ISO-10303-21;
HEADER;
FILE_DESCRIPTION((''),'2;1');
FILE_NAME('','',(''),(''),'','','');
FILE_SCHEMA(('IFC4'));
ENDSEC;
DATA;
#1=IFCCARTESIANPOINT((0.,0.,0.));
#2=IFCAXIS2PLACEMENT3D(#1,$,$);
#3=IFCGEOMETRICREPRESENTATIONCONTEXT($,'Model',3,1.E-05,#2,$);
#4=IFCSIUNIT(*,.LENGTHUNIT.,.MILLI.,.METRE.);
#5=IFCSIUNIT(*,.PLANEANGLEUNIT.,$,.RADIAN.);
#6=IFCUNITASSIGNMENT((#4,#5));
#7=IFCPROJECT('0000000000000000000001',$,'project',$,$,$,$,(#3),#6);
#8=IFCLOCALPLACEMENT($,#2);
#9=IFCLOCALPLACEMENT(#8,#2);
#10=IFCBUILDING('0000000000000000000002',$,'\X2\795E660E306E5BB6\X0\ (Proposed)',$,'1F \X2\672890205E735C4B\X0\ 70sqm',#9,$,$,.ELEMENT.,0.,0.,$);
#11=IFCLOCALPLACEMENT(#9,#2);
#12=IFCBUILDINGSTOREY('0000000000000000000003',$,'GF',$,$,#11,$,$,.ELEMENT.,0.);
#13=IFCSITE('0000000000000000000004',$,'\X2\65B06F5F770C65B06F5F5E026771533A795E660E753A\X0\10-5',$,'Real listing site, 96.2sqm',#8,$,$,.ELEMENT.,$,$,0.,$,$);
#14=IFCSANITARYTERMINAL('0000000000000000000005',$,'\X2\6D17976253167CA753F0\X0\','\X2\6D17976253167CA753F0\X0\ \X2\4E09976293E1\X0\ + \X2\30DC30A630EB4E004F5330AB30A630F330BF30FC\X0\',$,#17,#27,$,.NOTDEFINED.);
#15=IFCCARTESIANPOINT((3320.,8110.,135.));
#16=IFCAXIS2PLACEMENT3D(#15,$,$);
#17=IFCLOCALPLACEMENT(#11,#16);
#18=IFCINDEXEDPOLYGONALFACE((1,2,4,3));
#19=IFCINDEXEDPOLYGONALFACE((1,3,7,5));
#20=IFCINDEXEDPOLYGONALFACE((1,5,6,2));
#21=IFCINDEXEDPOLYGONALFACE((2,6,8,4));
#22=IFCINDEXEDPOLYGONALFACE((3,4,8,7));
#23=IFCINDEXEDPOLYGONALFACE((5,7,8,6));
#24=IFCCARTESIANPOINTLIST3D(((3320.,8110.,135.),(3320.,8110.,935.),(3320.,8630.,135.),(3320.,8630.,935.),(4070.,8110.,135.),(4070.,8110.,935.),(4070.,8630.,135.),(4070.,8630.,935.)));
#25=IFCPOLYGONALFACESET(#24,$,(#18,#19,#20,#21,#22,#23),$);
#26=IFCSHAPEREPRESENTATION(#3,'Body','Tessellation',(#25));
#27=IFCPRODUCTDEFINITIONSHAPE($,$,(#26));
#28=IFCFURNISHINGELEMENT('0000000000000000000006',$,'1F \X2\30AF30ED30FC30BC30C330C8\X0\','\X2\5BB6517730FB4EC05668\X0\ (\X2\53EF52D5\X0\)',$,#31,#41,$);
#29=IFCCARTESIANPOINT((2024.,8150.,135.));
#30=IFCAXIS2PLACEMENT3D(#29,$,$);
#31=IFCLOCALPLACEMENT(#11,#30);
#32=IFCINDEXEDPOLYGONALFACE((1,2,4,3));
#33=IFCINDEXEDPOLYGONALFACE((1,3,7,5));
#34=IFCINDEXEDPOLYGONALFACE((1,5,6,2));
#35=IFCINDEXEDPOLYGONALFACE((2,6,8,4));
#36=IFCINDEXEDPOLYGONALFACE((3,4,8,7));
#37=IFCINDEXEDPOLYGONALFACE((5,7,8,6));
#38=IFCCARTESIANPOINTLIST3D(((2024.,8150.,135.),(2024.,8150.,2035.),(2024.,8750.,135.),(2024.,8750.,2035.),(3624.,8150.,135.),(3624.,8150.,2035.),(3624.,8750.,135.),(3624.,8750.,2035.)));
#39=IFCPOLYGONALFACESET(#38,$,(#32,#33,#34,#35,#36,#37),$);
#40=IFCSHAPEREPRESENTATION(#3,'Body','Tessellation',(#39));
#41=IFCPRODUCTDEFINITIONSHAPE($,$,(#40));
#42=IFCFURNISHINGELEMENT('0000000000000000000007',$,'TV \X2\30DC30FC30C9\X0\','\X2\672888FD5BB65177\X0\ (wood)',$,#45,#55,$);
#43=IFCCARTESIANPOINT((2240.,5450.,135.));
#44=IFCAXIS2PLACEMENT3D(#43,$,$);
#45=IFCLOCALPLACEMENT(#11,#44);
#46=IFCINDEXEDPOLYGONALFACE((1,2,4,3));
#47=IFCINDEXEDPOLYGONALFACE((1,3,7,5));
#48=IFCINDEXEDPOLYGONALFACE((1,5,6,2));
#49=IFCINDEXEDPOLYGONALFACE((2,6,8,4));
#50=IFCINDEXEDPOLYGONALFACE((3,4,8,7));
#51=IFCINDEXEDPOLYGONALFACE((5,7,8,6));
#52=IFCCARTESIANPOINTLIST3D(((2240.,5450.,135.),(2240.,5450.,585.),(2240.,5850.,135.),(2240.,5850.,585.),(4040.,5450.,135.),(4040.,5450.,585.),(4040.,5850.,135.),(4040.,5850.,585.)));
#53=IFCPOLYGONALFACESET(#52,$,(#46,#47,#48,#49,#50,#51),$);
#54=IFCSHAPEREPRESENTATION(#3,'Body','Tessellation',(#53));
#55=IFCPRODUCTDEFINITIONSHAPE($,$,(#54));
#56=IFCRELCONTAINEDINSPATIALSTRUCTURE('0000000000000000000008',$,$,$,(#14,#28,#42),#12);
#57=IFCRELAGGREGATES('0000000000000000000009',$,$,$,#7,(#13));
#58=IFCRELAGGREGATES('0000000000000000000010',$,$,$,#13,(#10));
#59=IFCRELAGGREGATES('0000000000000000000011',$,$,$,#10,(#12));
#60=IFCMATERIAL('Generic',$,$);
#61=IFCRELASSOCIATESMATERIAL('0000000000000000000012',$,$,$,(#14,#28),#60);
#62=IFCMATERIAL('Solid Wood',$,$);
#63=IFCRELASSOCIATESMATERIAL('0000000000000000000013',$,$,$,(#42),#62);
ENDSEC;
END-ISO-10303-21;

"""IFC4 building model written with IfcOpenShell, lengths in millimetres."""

from ifc_helpers import new_model, si_unit, frame, frame_2d, origin, place, context, project, spatial, rectangle, extrude, material, element, save


model = new_model("IFC4")

# Units and contexts
model_context = context("Model", 3, precision=1e-05, world=origin())
ifc_project = project(units=[si_unit("LENGTHUNIT", "METRE", prefix="MILLI"), si_unit("PLANEANGLEUNIT", "RADIAN")], contexts=[model_context])

# Site, building, storey
site_placement = place(None, origin())
site = spatial("IfcSite", under=ifc_project, at=site_placement, Name="新潟県新潟市東区神明町10-5", ObjectType="Real listing site, 96.2sqm", CompositionType="ELEMENT", RefElevation=0.0)
building_placement = place(site_placement, origin())
building = spatial("IfcBuilding", under=site, at=building_placement, Name="神明の家 (Proposed)", ObjectType="1F 木造平屋 70sqm", CompositionType="ELEMENT", ElevationOfRefHeight=0.0, ElevationOfTerrain=0.0)
storey_placement = place(building_placement, origin())
storey = spatial("IfcBuildingStorey", under=building, at=storey_placement, Name="GF", CompositionType="ELEMENT", Elevation=0.0)

# Shared definitions
ifc_material_1 = material(Name="Solid Wood")

# Shared definitions
ifc_material_2 = material(Name="Generic")

# Sanitary terminal
sanitary_terminal_1_placement = place(storey_placement, frame((3320.0, 8110.0, 135.0)))
element("IfcSanitaryTerminal", 1, at=sanitary_terminal_1_placement, inside=storey, material=ifc_material_2, Name="洗面化粧台", Description="洗面化粧台 三面鏡 + ボウル一体カウンター", PredefinedType="NOTDEFINED", context=model_context, shape_type="SweptSolid", body=[
    extrude(rectangle(XDim=750.0, YDim=520.0, at=frame_2d((375.0, 260.0))), frame((3320.0, 8110.0, 135.0)), (0.0, 0.0, 1.0), 800.0),
])

# Furnishing elements
furnishing_1_placement = place(storey_placement, frame((2024.0, 8150.0, 135.0)))
element("IfcFurnishingElement", 2, at=furnishing_1_placement, inside=storey, material=ifc_material_2, Name="1F クローゼット", Description="家具・什器 (可動)", context=model_context, shape_type="SweptSolid", body=[
    extrude(rectangle(XDim=1600.0, YDim=600.0, at=frame_2d((800.0, 300.0))), frame((2024.0, 8150.0, 135.0)), (0.0, 0.0, 1.0), 1900.0),
])
furnishing_2_placement = place(storey_placement, frame((2240.0, 5450.0, 135.0)))
element("IfcFurnishingElement", 3, at=furnishing_2_placement, inside=storey, material=ifc_material_1, Name="TV ボード", Description="木製家具 (wood)", context=model_context, shape_type="SweptSolid", body=[
    extrude(rectangle(XDim=1800.0, YDim=400.0, at=frame_2d((900.0, 200.0))), frame((2240.0, 5450.0, 135.0)), (0.0, 0.0, 1.0), 450.0),
])

save(model, "model.ifc")
